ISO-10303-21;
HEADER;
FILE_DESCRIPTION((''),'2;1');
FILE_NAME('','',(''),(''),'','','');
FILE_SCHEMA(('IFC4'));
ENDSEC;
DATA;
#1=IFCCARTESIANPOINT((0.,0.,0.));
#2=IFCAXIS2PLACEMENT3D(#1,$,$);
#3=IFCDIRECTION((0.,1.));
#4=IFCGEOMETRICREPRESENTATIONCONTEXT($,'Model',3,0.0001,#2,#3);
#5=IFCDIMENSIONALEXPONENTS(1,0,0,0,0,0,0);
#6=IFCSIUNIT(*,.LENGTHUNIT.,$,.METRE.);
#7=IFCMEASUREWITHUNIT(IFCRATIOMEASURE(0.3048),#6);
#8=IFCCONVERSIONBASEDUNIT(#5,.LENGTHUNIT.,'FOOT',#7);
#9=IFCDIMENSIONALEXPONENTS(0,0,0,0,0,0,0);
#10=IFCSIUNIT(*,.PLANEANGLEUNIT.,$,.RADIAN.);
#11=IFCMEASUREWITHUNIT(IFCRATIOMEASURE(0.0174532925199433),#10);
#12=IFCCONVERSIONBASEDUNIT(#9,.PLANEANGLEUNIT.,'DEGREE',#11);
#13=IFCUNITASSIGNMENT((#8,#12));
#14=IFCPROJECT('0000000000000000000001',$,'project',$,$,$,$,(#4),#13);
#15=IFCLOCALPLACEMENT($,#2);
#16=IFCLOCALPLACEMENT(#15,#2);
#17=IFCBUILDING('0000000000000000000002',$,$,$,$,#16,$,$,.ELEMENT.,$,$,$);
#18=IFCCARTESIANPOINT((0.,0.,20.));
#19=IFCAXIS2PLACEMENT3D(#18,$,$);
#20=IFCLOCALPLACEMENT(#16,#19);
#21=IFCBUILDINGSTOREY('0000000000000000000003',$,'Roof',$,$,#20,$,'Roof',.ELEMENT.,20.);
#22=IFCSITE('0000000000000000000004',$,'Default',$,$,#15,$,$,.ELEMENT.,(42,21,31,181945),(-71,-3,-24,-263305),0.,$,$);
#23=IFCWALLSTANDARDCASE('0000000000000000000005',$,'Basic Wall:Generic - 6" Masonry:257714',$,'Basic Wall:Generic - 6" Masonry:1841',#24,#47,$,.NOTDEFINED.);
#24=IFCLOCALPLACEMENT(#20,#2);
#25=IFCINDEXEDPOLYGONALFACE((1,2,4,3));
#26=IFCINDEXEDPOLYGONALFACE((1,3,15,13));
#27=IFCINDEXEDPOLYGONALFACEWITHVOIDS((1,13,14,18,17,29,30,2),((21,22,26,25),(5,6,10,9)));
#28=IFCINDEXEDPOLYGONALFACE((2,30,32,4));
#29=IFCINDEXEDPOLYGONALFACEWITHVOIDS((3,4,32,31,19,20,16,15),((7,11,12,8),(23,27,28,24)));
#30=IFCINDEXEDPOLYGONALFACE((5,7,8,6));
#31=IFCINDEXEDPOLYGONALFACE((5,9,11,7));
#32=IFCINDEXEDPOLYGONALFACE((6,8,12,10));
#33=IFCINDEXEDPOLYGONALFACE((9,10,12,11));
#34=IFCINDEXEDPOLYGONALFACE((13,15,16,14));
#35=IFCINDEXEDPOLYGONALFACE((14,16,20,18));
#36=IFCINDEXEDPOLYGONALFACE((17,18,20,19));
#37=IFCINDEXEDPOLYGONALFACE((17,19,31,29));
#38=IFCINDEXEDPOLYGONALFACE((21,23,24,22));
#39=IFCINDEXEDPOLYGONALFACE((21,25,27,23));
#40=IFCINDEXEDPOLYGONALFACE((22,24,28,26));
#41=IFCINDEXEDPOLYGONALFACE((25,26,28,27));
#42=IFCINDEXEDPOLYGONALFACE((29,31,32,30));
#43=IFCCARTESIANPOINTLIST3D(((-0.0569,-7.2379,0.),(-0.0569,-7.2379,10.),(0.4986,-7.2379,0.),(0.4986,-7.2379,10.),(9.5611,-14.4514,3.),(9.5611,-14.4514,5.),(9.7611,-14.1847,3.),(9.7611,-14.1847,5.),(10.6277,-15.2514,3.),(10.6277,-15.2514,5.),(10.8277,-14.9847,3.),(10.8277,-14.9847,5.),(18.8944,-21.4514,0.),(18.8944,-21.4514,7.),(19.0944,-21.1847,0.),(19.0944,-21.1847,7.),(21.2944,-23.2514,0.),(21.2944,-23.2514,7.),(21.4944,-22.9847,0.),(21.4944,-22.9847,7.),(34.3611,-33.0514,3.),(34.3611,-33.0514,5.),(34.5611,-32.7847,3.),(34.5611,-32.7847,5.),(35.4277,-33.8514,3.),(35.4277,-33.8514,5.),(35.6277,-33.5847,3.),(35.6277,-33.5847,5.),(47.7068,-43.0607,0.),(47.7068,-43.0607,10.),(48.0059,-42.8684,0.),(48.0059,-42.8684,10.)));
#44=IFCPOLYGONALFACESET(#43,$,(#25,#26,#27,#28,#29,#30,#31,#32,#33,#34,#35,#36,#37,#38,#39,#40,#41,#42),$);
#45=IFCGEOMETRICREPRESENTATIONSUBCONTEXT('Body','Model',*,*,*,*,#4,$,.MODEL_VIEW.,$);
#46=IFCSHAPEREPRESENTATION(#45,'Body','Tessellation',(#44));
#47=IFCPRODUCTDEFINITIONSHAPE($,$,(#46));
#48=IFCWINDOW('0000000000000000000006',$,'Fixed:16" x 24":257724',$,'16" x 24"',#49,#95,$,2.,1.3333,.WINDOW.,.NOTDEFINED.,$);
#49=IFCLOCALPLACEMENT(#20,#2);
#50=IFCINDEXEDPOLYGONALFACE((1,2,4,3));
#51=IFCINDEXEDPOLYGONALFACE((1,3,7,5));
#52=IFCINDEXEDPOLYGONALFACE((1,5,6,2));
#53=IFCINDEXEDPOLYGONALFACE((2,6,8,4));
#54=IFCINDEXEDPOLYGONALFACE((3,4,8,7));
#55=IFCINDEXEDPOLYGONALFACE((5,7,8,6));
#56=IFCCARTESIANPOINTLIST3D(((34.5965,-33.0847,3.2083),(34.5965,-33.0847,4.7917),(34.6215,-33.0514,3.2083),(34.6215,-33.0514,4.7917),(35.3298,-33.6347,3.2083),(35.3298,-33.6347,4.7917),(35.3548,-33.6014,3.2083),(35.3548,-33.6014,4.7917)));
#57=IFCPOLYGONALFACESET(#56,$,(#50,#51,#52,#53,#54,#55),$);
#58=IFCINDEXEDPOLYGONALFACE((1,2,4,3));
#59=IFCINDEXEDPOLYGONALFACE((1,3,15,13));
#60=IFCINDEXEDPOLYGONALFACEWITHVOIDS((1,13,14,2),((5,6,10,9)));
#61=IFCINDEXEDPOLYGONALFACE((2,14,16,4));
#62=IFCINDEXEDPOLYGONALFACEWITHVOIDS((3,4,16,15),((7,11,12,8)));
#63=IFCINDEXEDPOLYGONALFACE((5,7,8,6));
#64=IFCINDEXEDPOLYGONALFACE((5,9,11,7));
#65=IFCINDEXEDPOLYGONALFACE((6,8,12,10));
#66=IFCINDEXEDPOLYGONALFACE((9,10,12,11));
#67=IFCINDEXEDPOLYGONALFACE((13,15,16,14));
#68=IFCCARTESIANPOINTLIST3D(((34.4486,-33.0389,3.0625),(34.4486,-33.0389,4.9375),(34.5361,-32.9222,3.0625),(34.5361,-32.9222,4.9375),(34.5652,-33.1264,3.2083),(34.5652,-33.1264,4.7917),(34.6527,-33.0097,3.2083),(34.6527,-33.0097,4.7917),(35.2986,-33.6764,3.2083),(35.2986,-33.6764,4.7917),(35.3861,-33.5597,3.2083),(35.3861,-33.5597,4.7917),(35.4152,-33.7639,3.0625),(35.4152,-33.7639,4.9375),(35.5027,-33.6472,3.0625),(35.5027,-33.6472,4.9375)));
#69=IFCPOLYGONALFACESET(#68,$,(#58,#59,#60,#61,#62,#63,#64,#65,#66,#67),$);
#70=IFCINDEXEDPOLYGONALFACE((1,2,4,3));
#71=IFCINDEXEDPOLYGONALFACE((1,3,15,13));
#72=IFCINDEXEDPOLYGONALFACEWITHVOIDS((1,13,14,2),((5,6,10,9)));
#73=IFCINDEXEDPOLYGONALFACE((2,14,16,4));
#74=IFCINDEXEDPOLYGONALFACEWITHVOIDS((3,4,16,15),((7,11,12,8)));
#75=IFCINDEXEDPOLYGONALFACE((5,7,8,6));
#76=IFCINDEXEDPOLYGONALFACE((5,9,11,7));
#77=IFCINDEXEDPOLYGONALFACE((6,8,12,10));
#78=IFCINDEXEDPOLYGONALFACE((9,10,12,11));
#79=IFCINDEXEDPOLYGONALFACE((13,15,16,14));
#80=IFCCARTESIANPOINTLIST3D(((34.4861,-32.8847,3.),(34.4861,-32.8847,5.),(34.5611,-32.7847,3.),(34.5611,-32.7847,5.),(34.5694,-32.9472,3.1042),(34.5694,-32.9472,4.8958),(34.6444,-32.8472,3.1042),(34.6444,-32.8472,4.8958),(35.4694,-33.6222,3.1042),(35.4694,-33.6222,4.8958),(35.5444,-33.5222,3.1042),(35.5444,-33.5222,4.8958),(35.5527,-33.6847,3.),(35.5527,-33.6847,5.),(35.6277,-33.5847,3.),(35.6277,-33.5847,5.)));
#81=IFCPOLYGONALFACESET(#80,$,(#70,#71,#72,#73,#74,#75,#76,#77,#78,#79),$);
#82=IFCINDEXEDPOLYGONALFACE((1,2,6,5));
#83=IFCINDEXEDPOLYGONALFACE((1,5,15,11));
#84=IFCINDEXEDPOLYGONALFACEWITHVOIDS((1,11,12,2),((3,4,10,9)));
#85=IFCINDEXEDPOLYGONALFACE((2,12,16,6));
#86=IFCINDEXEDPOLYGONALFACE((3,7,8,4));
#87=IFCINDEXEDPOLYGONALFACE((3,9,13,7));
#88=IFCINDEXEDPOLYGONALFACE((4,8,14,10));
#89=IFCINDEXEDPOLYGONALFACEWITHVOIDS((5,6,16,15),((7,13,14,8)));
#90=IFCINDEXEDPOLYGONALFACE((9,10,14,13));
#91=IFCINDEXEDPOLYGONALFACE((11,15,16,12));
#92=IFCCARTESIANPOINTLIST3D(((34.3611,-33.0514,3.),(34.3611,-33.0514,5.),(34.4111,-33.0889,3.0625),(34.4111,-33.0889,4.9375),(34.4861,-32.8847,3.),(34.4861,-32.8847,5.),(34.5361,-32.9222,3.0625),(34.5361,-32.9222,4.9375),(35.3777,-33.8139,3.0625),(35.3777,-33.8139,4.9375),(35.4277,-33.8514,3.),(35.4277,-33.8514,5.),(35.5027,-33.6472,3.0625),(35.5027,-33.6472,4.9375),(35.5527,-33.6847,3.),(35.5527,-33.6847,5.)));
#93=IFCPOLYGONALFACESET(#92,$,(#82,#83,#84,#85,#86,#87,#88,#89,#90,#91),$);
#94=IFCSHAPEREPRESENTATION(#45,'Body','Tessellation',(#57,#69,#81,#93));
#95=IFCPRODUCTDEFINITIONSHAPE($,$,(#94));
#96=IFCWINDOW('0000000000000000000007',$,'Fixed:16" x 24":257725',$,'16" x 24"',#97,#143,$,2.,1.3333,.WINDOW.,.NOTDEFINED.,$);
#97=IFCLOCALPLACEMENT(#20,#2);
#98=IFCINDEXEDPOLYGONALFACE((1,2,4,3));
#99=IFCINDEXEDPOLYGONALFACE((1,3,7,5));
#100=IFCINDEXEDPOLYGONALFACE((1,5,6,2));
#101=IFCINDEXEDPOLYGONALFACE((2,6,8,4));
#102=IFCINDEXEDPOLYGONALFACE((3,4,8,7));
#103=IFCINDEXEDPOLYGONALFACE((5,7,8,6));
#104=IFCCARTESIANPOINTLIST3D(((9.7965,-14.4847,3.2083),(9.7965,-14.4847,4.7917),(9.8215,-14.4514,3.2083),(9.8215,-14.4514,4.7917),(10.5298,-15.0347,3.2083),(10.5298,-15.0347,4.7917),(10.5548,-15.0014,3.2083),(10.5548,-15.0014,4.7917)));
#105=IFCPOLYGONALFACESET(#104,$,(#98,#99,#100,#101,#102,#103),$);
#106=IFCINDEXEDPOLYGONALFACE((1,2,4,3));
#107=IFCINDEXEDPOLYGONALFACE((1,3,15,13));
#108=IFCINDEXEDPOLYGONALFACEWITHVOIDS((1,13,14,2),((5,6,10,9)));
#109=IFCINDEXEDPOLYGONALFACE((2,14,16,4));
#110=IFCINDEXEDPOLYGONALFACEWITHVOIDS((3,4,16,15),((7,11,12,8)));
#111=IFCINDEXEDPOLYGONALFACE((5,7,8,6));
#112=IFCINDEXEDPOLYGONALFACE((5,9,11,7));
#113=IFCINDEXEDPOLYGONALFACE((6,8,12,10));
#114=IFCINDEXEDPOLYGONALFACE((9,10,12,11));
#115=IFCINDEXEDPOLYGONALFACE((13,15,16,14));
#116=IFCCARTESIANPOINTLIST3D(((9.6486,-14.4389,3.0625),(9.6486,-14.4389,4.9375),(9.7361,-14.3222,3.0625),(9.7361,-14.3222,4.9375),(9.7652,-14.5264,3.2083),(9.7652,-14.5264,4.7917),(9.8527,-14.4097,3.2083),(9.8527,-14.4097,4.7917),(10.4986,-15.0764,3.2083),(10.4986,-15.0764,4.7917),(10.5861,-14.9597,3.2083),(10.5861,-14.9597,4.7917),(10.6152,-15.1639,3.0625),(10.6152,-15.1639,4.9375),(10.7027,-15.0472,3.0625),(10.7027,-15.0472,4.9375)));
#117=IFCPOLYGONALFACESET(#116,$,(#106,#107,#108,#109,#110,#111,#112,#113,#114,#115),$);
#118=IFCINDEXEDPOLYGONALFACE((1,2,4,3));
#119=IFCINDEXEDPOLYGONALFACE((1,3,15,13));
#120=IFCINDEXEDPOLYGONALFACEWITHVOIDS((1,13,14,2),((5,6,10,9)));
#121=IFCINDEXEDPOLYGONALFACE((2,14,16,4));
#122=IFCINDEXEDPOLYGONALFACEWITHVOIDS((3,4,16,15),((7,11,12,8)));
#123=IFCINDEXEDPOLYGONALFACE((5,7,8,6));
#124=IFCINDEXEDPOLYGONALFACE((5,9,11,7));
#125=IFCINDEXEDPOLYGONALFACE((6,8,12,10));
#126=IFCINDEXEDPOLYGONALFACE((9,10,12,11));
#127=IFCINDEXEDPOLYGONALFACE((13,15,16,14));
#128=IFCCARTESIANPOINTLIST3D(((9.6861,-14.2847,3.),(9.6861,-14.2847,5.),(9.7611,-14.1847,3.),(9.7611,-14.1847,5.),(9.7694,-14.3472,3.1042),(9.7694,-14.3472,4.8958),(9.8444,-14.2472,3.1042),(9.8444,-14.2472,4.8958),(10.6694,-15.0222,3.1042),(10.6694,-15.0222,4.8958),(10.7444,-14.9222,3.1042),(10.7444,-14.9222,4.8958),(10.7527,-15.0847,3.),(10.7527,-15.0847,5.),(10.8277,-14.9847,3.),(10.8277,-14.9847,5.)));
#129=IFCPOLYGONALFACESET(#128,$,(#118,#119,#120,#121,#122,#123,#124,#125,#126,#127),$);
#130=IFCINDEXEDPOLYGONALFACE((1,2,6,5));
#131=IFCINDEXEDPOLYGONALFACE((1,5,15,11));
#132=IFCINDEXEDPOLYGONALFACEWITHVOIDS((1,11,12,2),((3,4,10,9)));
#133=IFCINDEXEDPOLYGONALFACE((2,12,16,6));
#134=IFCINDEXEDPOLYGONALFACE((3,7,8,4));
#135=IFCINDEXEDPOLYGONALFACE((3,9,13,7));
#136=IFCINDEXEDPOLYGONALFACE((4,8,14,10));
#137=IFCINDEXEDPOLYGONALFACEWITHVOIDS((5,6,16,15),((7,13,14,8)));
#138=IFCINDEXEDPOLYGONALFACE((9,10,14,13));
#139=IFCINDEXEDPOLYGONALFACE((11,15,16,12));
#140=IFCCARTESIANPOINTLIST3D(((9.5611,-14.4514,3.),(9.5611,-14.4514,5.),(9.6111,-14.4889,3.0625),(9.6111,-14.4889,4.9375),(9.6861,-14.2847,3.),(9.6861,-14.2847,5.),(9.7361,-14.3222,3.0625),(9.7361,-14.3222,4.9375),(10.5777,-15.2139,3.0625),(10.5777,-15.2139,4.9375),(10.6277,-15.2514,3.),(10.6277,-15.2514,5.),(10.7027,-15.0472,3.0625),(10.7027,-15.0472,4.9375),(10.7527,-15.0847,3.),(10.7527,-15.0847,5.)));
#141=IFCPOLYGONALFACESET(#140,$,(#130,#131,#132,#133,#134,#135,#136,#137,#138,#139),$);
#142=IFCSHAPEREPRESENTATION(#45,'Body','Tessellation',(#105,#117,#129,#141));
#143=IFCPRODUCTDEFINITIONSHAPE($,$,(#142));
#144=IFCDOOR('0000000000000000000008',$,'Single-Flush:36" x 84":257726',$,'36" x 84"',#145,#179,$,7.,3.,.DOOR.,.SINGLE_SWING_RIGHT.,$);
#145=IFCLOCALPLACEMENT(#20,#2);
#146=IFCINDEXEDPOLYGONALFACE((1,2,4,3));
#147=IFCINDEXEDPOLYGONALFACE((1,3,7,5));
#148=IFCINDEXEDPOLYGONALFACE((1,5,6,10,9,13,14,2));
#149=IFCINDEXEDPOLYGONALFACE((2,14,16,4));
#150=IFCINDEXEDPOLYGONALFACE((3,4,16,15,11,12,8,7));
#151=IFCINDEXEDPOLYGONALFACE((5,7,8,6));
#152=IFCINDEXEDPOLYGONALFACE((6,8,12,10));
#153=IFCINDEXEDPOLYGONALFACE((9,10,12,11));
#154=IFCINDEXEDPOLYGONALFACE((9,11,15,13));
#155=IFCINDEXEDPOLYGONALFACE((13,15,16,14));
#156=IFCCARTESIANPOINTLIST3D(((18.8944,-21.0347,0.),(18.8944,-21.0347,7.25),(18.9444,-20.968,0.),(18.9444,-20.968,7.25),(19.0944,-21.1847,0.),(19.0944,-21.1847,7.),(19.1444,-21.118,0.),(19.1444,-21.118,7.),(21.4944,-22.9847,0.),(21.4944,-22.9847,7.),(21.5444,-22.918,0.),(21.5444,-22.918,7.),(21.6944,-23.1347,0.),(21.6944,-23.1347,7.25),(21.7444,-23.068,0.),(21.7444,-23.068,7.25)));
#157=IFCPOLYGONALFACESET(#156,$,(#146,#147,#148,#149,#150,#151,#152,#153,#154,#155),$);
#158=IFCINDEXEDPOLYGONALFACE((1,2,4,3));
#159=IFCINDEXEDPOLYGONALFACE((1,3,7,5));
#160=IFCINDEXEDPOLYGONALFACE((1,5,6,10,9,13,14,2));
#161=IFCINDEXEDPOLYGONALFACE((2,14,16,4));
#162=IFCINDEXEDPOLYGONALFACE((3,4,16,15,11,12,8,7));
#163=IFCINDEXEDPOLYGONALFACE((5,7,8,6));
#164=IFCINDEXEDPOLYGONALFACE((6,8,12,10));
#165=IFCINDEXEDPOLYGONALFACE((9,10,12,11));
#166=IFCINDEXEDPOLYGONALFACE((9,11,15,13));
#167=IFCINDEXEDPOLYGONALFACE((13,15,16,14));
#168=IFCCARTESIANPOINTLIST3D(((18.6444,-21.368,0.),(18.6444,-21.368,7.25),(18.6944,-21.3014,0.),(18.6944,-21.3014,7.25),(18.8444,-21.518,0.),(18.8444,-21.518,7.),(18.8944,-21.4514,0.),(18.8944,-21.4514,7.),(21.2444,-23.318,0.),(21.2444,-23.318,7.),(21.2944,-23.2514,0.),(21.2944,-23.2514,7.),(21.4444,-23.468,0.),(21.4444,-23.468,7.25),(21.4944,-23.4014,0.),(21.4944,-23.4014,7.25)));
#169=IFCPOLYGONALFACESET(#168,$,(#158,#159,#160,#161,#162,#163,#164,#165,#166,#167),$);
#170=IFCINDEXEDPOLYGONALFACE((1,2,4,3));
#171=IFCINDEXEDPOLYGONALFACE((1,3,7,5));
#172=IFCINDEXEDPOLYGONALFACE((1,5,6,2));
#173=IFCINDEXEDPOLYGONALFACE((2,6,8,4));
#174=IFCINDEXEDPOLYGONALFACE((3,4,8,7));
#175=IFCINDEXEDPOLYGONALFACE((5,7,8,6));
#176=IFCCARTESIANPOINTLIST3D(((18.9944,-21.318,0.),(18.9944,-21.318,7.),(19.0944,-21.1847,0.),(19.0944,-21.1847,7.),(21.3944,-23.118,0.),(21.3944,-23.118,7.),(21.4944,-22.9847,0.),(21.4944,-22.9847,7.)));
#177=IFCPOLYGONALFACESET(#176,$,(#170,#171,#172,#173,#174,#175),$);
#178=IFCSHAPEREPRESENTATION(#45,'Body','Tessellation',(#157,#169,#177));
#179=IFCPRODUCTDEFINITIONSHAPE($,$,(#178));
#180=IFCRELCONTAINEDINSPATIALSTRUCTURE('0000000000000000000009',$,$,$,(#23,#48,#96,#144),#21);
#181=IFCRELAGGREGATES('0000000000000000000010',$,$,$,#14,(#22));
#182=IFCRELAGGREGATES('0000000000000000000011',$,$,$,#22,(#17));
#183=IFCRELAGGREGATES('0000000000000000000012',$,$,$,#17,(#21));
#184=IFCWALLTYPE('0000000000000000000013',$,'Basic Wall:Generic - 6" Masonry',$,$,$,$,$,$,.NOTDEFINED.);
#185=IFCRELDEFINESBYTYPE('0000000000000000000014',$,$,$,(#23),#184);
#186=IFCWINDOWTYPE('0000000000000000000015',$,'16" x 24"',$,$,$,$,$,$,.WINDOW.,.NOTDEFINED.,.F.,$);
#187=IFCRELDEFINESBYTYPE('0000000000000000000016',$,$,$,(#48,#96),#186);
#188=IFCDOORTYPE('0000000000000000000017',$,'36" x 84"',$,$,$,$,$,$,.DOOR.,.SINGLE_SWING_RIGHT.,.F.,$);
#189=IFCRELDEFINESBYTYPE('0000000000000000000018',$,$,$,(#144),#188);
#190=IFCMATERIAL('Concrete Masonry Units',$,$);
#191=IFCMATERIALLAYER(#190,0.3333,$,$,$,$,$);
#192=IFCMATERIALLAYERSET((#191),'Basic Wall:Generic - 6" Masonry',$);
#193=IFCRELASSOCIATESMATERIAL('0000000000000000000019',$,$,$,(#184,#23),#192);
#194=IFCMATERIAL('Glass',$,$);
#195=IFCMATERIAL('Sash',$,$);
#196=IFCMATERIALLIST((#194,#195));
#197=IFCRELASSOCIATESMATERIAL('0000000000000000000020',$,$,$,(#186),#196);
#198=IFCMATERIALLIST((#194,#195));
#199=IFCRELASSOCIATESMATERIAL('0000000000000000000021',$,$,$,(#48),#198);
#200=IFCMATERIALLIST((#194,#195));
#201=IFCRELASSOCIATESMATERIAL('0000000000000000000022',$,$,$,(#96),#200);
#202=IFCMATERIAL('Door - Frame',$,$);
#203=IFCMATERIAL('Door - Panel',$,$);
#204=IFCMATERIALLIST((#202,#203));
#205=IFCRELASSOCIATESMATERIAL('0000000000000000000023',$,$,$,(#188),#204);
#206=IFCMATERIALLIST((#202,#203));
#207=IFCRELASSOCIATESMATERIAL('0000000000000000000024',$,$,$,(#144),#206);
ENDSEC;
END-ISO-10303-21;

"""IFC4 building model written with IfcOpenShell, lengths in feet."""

from ifc_helpers import new_model, entity, si_unit, converted_unit, direction, frame, frame_2d, origin, origin_2d_with_axis, place, context, subcontext, project, spatial, polyline, rectangle, outline, extrude, source, transform, mapped, material, material_list, layer, layer_set, layer_usage, type_object, type_shapes, element, fill, save


model = new_model("IFC4")

# Units and contexts
model_context = context("Model", 3, precision=0.0001, world=origin(), true_north=direction((0.0, 1.0)))
body_context = subcontext(model_context, "Body", "Model", "MODEL_VIEW")
ifc_project = project(units=[converted_unit("LENGTHUNIT", "FOOT", entity("IfcRatioMeasure", 0.3048), si_unit("LENGTHUNIT", "METRE"), dimensions=[1, 0, 0, 0, 0, 0, 0]), converted_unit("PLANEANGLEUNIT", "DEGREE", entity("IfcRatioMeasure", 0.0174532925199433), si_unit("PLANEANGLEUNIT", "RADIAN"), dimensions=[0, 0, 0, 0, 0, 0, 0])], contexts=[model_context])

# Site, building, storey
site_placement = place(None, origin())
site = spatial("IfcSite", under=ifc_project, at=site_placement, Name="Default", CompositionType="ELEMENT", RefLatitude=(42, 21, 31, 181945), RefLongitude=(-71, -3, -24, -263305), RefElevation=0.0)
building_placement = place(site_placement, origin())
building = spatial("IfcBuilding", under=site, at=building_placement, CompositionType="ELEMENT")
storey_placement = place(building_placement, frame((0.0, 0.0, 20.0)))
storey = spatial("IfcBuildingStorey", under=building, at=storey_placement, Name="Roof", LongName="Roof", CompositionType="ELEMENT", Elevation=20.0)

# Wall, openings, windows, door
ifc_material_1 = material(Name="Concrete Masonry Units")
ifc_layer = layer(ifc_material_1, 0.3333)
ifc_layer_set = layer_set([ifc_layer], Name="Basic Wall:Generic - 6\" Masonry")
ifc_layer_usage = layer_usage(ifc_layer_set, "AXIS2", "NEGATIVE", 0.1667)
wall_type = type_object("IfcWallType", Name="Basic Wall:Generic - 6\" Masonry", PredefinedType="NOTDEFINED", material=ifc_layer_set)
wall_placement = place(storey_placement, frame((47.9059, -43.0017, 0.0), z_axis=(0.0, 0.0, 1.0), x_axis=(-0.8, 0.6, 0.0)))
wall = element("IfcWallStandardCase", 1, at=wall_placement, inside=storey, type_object=wall_type, material=ifc_layer_usage, Name="Basic Wall:Generic - 6\" Masonry:257714", ObjectType="Basic Wall:Generic - 6\" Masonry:1841", PredefinedType="NOTDEFINED", context=body_context, shape_type="SweptSolid", body=[
    extrude(outline(polyline([(0.0, -0.1667), (59.3842, -0.1667), (59.8286, 0.1667), (0.1239, 0.1667), (0.0, -0.1667)])), origin(), (0.0, 0.0, 1.0), 10.0),
])
opening_1_placement = place(wall_placement, frame((36.1394, 0.1667, 0.0)))
opening_1 = element("IfcOpeningElement", 2, at=opening_1_placement, cuts=wall, ObjectType="Opening", PredefinedType="OPENING", context=body_context, shape_type="SweptSolid", body=[
    extrude(rectangle(XDim=3.0, YDim=7.0, at=frame_2d((3.5, 1.5), x_axis=(0.0, 1.0))), frame((0.0, 0.0, 0.0), z_axis=(0.0, -1.0, 0.0), x_axis=(0.0, 0.0, 1.0)), (0.0, 0.0, 1.0), 0.3333),
])
opening_2_placement = place(wall_placement, frame((15.4728, -0.1667, 3.0)))
opening_2 = element("IfcOpeningElement", 3, at=opening_2_placement, cuts=wall, ObjectType="Opening", PredefinedType="OPENING", context=body_context, shape_type="SweptSolid", body=[
    extrude(rectangle(XDim=2.0, YDim=1.3333, at=frame_2d((1.0, 0.6667), x_axis=(-1.0, 0.0))), frame((0.0, 0.0, 0.0), z_axis=(0.0, 1.0, 0.0), x_axis=(0.0, 0.0, 1.0)), (0.0, 0.0, 1.0), 0.3333),
])
opening_3_placement = place(wall_placement, frame((46.4728, -0.1667, 3.0)))
opening_3 = element("IfcOpeningElement", 4, at=opening_3_placement, cuts=wall, ObjectType="Opening", PredefinedType="OPENING", context=body_context, shape_type="SweptSolid", body=[
    extrude(rectangle(XDim=2.0, YDim=1.3333, at=frame_2d((1.0, 0.6667), x_axis=(-1.0, 0.0))), frame((0.0, 0.0, 0.0), z_axis=(0.0, 1.0, 0.0), x_axis=(0.0, 0.0, 1.0)), (0.0, 0.0, 1.0), 0.3333),
])
ifc_material_2 = material(Name="Glass")
ifc_material_3 = material(Name="Sash")
ifc_material_list_1 = material_list([ifc_material_2, ifc_material_3])
ifc_material_list_2 = material_list([ifc_material_2, ifc_material_3])
window_type = type_object("IfcWindowType", Name="16\" x 24\"", ParameterTakesPrecedence=False, PartitioningType="NOTDEFINED", PredefinedType="WINDOW", material=ifc_material_list_2)
shared_shape_1 = source(origin(), body_context, "Body", "SweptSolid", [
    extrude(rectangle(XDim=0.0417, YDim=0.9167, at=origin_2d_with_axis()), frame((0.6667, 0.1979, 0.2083), z_axis=(0.0, 0.0, 1.0), x_axis=(0.0, 1.0, 0.0)), (0.0, 0.0, 1.0), 1.5833),
    extrude(outline(polyline([(-0.6042, -0.9375), (0.6042, -0.9375), (0.6042, 0.9375), (-0.6042, 0.9375), (-0.6042, -0.9375)]), holes=[polyline([(-0.4583, -0.7917), (-0.4583, 0.7917), (0.4583, 0.7917), (0.4583, -0.7917), (-0.4583, -0.7917)])]), frame((0.6667, 0.125, 1.0), z_axis=(0.0, 1.0, 0.0), x_axis=(1.0, 0.0, 0.0)), (0.0, 0.0, 1.0), 0.1458),
    extrude(outline(polyline([(-0.6667, -1.0), (0.6667, -1.0), (0.6667, 1.0), (-0.6667, 1.0), (-0.6667, -1.0)]), holes=[polyline([(-0.5625, -0.8958), (-0.5625, 0.8958), (0.5625, 0.8958), (0.5625, -0.8958), (-0.5625, -0.8958)])]), frame((0.6667, 0.0, 1.0), z_axis=(0.0, 1.0, 0.0), x_axis=(1.0, 0.0, 0.0)), (0.0, 0.0, 1.0), 0.125),
    extrude(outline(polyline([(-1.0, -0.6667), (1.0, -0.6667), (1.0, 0.6667), (-1.0, 0.6667), (-1.0, -0.6667)]), holes=[polyline([(-0.9375, -0.6042), (-0.9375, 0.6042), (0.9375, 0.6042), (0.9375, -0.6042), (-0.9375, -0.6042)])]), frame((0.6667, 0.125, 1.0), z_axis=(0.0, 1.0, 0.0), x_axis=(0.0, 0.0, -1.0)), (0.0, 0.0, 1.0), 0.2083),
])
type_shapes(window_type, [shared_shape_1])
window_1_placement = place(opening_2_placement, origin())
window_1 = element("IfcWindow", 5, at=window_1_placement, inside=storey, type_object=window_type, material=ifc_material_list_1, Name="Fixed:16\" x 24\":257724", ObjectType="16\" x 24\"", OverallHeight=2.0, OverallWidth=1.3333, PartitioningType="NOTDEFINED", PredefinedType="WINDOW", context=body_context, shape_type="MappedRepresentation", body=[
    mapped(shared_shape_1, transform((0.0, 0.0, 0.0), scale=1.0)),
])
fill(opening_2, window_1)
ifc_material_list_3 = material_list([ifc_material_2, ifc_material_3])
window_2_placement = place(opening_3_placement, origin())
window_2 = element("IfcWindow", 6, at=window_2_placement, inside=storey, type_object=window_type, material=ifc_material_list_3, Name="Fixed:16\" x 24\":257725", ObjectType="16\" x 24\"", OverallHeight=2.0, OverallWidth=1.3333, PartitioningType="NOTDEFINED", PredefinedType="WINDOW", context=body_context, shape_type="MappedRepresentation", body=[
    mapped(shared_shape_1, transform((0.0, 0.0, 0.0), scale=1.0)),
])
fill(opening_3, window_2)
ifc_material_4 = material(Name="Door - Frame")
ifc_material_5 = material(Name="Door - Panel")
ifc_material_list_4 = material_list([ifc_material_4, ifc_material_5])
ifc_material_list_5 = material_list([ifc_material_4, ifc_material_5])
door_type = type_object("IfcDoorType", Name="36\" x 84\"", OperationType="SINGLE_SWING_RIGHT", ParameterTakesPrecedence=False, PredefinedType="DOOR", material=ifc_material_list_5)
shared_shape_2 = source(origin(), body_context, "Body", "SweptSolid", [
    extrude(outline(polyline([(-1.75, -3.6875), (1.75, -3.6875), (1.75, 3.5625), (1.5, 3.5625), (1.5, -3.4375), (-1.5, -3.4375), (-1.5, 3.5625), (-1.75, 3.5625), (-1.75, -3.6875)])), frame((1.5, 0.3333, 3.5625), z_axis=(0.0, 1.0, 0.0), x_axis=(1.0, 0.0, 0.0)), (0.0, 0.0, 1.0), 0.0833),
    extrude(outline(polyline([(-3.6875, -1.75), (3.5625, -1.75), (3.5625, -1.5), (-3.4375, -1.5), (-3.4375, 1.5), (3.5625, 1.5), (3.5625, 1.75), (-3.6875, 1.75), (-3.6875, -1.75)])), frame((1.5, -0.0833, 3.5625), z_axis=(0.0, 1.0, 0.0), x_axis=(0.0, 0.0, -1.0)), (0.0, 0.0, 1.0), 0.0833),
    extrude(rectangle(XDim=0.1667, YDim=3.0, at=frame_2d((0.0, 0.0), x_axis=(1.0, 0.0))), frame((1.5, 0.25, 0.0), z_axis=(0.0, 0.0, 1.0), x_axis=(0.0, 1.0, 0.0)), (0.0, 0.0, 1.0), 7.0),
])
type_shapes(door_type, [shared_shape_2])
door_placement = place(opening_1_placement, frame((0.0, 0.0, 0.0), z_axis=(0.0, 0.0, 1.0), x_axis=(-1.0, 0.0, 0.0)))
door = element("IfcDoor", 7, at=door_placement, inside=storey, type_object=door_type, material=ifc_material_list_4, Name="Single-Flush:36\" x 84\":257726", ObjectType="36\" x 84\"", OperationType="SINGLE_SWING_RIGHT", OverallHeight=7.0, OverallWidth=3.0, PredefinedType="DOOR", context=body_context, shape_type="MappedRepresentation", body=[
    mapped(shared_shape_2, transform((0.0, 0.0, 0.0), scale=1.0)),
])
fill(opening_1, door)

save(model, "model.ifc")
